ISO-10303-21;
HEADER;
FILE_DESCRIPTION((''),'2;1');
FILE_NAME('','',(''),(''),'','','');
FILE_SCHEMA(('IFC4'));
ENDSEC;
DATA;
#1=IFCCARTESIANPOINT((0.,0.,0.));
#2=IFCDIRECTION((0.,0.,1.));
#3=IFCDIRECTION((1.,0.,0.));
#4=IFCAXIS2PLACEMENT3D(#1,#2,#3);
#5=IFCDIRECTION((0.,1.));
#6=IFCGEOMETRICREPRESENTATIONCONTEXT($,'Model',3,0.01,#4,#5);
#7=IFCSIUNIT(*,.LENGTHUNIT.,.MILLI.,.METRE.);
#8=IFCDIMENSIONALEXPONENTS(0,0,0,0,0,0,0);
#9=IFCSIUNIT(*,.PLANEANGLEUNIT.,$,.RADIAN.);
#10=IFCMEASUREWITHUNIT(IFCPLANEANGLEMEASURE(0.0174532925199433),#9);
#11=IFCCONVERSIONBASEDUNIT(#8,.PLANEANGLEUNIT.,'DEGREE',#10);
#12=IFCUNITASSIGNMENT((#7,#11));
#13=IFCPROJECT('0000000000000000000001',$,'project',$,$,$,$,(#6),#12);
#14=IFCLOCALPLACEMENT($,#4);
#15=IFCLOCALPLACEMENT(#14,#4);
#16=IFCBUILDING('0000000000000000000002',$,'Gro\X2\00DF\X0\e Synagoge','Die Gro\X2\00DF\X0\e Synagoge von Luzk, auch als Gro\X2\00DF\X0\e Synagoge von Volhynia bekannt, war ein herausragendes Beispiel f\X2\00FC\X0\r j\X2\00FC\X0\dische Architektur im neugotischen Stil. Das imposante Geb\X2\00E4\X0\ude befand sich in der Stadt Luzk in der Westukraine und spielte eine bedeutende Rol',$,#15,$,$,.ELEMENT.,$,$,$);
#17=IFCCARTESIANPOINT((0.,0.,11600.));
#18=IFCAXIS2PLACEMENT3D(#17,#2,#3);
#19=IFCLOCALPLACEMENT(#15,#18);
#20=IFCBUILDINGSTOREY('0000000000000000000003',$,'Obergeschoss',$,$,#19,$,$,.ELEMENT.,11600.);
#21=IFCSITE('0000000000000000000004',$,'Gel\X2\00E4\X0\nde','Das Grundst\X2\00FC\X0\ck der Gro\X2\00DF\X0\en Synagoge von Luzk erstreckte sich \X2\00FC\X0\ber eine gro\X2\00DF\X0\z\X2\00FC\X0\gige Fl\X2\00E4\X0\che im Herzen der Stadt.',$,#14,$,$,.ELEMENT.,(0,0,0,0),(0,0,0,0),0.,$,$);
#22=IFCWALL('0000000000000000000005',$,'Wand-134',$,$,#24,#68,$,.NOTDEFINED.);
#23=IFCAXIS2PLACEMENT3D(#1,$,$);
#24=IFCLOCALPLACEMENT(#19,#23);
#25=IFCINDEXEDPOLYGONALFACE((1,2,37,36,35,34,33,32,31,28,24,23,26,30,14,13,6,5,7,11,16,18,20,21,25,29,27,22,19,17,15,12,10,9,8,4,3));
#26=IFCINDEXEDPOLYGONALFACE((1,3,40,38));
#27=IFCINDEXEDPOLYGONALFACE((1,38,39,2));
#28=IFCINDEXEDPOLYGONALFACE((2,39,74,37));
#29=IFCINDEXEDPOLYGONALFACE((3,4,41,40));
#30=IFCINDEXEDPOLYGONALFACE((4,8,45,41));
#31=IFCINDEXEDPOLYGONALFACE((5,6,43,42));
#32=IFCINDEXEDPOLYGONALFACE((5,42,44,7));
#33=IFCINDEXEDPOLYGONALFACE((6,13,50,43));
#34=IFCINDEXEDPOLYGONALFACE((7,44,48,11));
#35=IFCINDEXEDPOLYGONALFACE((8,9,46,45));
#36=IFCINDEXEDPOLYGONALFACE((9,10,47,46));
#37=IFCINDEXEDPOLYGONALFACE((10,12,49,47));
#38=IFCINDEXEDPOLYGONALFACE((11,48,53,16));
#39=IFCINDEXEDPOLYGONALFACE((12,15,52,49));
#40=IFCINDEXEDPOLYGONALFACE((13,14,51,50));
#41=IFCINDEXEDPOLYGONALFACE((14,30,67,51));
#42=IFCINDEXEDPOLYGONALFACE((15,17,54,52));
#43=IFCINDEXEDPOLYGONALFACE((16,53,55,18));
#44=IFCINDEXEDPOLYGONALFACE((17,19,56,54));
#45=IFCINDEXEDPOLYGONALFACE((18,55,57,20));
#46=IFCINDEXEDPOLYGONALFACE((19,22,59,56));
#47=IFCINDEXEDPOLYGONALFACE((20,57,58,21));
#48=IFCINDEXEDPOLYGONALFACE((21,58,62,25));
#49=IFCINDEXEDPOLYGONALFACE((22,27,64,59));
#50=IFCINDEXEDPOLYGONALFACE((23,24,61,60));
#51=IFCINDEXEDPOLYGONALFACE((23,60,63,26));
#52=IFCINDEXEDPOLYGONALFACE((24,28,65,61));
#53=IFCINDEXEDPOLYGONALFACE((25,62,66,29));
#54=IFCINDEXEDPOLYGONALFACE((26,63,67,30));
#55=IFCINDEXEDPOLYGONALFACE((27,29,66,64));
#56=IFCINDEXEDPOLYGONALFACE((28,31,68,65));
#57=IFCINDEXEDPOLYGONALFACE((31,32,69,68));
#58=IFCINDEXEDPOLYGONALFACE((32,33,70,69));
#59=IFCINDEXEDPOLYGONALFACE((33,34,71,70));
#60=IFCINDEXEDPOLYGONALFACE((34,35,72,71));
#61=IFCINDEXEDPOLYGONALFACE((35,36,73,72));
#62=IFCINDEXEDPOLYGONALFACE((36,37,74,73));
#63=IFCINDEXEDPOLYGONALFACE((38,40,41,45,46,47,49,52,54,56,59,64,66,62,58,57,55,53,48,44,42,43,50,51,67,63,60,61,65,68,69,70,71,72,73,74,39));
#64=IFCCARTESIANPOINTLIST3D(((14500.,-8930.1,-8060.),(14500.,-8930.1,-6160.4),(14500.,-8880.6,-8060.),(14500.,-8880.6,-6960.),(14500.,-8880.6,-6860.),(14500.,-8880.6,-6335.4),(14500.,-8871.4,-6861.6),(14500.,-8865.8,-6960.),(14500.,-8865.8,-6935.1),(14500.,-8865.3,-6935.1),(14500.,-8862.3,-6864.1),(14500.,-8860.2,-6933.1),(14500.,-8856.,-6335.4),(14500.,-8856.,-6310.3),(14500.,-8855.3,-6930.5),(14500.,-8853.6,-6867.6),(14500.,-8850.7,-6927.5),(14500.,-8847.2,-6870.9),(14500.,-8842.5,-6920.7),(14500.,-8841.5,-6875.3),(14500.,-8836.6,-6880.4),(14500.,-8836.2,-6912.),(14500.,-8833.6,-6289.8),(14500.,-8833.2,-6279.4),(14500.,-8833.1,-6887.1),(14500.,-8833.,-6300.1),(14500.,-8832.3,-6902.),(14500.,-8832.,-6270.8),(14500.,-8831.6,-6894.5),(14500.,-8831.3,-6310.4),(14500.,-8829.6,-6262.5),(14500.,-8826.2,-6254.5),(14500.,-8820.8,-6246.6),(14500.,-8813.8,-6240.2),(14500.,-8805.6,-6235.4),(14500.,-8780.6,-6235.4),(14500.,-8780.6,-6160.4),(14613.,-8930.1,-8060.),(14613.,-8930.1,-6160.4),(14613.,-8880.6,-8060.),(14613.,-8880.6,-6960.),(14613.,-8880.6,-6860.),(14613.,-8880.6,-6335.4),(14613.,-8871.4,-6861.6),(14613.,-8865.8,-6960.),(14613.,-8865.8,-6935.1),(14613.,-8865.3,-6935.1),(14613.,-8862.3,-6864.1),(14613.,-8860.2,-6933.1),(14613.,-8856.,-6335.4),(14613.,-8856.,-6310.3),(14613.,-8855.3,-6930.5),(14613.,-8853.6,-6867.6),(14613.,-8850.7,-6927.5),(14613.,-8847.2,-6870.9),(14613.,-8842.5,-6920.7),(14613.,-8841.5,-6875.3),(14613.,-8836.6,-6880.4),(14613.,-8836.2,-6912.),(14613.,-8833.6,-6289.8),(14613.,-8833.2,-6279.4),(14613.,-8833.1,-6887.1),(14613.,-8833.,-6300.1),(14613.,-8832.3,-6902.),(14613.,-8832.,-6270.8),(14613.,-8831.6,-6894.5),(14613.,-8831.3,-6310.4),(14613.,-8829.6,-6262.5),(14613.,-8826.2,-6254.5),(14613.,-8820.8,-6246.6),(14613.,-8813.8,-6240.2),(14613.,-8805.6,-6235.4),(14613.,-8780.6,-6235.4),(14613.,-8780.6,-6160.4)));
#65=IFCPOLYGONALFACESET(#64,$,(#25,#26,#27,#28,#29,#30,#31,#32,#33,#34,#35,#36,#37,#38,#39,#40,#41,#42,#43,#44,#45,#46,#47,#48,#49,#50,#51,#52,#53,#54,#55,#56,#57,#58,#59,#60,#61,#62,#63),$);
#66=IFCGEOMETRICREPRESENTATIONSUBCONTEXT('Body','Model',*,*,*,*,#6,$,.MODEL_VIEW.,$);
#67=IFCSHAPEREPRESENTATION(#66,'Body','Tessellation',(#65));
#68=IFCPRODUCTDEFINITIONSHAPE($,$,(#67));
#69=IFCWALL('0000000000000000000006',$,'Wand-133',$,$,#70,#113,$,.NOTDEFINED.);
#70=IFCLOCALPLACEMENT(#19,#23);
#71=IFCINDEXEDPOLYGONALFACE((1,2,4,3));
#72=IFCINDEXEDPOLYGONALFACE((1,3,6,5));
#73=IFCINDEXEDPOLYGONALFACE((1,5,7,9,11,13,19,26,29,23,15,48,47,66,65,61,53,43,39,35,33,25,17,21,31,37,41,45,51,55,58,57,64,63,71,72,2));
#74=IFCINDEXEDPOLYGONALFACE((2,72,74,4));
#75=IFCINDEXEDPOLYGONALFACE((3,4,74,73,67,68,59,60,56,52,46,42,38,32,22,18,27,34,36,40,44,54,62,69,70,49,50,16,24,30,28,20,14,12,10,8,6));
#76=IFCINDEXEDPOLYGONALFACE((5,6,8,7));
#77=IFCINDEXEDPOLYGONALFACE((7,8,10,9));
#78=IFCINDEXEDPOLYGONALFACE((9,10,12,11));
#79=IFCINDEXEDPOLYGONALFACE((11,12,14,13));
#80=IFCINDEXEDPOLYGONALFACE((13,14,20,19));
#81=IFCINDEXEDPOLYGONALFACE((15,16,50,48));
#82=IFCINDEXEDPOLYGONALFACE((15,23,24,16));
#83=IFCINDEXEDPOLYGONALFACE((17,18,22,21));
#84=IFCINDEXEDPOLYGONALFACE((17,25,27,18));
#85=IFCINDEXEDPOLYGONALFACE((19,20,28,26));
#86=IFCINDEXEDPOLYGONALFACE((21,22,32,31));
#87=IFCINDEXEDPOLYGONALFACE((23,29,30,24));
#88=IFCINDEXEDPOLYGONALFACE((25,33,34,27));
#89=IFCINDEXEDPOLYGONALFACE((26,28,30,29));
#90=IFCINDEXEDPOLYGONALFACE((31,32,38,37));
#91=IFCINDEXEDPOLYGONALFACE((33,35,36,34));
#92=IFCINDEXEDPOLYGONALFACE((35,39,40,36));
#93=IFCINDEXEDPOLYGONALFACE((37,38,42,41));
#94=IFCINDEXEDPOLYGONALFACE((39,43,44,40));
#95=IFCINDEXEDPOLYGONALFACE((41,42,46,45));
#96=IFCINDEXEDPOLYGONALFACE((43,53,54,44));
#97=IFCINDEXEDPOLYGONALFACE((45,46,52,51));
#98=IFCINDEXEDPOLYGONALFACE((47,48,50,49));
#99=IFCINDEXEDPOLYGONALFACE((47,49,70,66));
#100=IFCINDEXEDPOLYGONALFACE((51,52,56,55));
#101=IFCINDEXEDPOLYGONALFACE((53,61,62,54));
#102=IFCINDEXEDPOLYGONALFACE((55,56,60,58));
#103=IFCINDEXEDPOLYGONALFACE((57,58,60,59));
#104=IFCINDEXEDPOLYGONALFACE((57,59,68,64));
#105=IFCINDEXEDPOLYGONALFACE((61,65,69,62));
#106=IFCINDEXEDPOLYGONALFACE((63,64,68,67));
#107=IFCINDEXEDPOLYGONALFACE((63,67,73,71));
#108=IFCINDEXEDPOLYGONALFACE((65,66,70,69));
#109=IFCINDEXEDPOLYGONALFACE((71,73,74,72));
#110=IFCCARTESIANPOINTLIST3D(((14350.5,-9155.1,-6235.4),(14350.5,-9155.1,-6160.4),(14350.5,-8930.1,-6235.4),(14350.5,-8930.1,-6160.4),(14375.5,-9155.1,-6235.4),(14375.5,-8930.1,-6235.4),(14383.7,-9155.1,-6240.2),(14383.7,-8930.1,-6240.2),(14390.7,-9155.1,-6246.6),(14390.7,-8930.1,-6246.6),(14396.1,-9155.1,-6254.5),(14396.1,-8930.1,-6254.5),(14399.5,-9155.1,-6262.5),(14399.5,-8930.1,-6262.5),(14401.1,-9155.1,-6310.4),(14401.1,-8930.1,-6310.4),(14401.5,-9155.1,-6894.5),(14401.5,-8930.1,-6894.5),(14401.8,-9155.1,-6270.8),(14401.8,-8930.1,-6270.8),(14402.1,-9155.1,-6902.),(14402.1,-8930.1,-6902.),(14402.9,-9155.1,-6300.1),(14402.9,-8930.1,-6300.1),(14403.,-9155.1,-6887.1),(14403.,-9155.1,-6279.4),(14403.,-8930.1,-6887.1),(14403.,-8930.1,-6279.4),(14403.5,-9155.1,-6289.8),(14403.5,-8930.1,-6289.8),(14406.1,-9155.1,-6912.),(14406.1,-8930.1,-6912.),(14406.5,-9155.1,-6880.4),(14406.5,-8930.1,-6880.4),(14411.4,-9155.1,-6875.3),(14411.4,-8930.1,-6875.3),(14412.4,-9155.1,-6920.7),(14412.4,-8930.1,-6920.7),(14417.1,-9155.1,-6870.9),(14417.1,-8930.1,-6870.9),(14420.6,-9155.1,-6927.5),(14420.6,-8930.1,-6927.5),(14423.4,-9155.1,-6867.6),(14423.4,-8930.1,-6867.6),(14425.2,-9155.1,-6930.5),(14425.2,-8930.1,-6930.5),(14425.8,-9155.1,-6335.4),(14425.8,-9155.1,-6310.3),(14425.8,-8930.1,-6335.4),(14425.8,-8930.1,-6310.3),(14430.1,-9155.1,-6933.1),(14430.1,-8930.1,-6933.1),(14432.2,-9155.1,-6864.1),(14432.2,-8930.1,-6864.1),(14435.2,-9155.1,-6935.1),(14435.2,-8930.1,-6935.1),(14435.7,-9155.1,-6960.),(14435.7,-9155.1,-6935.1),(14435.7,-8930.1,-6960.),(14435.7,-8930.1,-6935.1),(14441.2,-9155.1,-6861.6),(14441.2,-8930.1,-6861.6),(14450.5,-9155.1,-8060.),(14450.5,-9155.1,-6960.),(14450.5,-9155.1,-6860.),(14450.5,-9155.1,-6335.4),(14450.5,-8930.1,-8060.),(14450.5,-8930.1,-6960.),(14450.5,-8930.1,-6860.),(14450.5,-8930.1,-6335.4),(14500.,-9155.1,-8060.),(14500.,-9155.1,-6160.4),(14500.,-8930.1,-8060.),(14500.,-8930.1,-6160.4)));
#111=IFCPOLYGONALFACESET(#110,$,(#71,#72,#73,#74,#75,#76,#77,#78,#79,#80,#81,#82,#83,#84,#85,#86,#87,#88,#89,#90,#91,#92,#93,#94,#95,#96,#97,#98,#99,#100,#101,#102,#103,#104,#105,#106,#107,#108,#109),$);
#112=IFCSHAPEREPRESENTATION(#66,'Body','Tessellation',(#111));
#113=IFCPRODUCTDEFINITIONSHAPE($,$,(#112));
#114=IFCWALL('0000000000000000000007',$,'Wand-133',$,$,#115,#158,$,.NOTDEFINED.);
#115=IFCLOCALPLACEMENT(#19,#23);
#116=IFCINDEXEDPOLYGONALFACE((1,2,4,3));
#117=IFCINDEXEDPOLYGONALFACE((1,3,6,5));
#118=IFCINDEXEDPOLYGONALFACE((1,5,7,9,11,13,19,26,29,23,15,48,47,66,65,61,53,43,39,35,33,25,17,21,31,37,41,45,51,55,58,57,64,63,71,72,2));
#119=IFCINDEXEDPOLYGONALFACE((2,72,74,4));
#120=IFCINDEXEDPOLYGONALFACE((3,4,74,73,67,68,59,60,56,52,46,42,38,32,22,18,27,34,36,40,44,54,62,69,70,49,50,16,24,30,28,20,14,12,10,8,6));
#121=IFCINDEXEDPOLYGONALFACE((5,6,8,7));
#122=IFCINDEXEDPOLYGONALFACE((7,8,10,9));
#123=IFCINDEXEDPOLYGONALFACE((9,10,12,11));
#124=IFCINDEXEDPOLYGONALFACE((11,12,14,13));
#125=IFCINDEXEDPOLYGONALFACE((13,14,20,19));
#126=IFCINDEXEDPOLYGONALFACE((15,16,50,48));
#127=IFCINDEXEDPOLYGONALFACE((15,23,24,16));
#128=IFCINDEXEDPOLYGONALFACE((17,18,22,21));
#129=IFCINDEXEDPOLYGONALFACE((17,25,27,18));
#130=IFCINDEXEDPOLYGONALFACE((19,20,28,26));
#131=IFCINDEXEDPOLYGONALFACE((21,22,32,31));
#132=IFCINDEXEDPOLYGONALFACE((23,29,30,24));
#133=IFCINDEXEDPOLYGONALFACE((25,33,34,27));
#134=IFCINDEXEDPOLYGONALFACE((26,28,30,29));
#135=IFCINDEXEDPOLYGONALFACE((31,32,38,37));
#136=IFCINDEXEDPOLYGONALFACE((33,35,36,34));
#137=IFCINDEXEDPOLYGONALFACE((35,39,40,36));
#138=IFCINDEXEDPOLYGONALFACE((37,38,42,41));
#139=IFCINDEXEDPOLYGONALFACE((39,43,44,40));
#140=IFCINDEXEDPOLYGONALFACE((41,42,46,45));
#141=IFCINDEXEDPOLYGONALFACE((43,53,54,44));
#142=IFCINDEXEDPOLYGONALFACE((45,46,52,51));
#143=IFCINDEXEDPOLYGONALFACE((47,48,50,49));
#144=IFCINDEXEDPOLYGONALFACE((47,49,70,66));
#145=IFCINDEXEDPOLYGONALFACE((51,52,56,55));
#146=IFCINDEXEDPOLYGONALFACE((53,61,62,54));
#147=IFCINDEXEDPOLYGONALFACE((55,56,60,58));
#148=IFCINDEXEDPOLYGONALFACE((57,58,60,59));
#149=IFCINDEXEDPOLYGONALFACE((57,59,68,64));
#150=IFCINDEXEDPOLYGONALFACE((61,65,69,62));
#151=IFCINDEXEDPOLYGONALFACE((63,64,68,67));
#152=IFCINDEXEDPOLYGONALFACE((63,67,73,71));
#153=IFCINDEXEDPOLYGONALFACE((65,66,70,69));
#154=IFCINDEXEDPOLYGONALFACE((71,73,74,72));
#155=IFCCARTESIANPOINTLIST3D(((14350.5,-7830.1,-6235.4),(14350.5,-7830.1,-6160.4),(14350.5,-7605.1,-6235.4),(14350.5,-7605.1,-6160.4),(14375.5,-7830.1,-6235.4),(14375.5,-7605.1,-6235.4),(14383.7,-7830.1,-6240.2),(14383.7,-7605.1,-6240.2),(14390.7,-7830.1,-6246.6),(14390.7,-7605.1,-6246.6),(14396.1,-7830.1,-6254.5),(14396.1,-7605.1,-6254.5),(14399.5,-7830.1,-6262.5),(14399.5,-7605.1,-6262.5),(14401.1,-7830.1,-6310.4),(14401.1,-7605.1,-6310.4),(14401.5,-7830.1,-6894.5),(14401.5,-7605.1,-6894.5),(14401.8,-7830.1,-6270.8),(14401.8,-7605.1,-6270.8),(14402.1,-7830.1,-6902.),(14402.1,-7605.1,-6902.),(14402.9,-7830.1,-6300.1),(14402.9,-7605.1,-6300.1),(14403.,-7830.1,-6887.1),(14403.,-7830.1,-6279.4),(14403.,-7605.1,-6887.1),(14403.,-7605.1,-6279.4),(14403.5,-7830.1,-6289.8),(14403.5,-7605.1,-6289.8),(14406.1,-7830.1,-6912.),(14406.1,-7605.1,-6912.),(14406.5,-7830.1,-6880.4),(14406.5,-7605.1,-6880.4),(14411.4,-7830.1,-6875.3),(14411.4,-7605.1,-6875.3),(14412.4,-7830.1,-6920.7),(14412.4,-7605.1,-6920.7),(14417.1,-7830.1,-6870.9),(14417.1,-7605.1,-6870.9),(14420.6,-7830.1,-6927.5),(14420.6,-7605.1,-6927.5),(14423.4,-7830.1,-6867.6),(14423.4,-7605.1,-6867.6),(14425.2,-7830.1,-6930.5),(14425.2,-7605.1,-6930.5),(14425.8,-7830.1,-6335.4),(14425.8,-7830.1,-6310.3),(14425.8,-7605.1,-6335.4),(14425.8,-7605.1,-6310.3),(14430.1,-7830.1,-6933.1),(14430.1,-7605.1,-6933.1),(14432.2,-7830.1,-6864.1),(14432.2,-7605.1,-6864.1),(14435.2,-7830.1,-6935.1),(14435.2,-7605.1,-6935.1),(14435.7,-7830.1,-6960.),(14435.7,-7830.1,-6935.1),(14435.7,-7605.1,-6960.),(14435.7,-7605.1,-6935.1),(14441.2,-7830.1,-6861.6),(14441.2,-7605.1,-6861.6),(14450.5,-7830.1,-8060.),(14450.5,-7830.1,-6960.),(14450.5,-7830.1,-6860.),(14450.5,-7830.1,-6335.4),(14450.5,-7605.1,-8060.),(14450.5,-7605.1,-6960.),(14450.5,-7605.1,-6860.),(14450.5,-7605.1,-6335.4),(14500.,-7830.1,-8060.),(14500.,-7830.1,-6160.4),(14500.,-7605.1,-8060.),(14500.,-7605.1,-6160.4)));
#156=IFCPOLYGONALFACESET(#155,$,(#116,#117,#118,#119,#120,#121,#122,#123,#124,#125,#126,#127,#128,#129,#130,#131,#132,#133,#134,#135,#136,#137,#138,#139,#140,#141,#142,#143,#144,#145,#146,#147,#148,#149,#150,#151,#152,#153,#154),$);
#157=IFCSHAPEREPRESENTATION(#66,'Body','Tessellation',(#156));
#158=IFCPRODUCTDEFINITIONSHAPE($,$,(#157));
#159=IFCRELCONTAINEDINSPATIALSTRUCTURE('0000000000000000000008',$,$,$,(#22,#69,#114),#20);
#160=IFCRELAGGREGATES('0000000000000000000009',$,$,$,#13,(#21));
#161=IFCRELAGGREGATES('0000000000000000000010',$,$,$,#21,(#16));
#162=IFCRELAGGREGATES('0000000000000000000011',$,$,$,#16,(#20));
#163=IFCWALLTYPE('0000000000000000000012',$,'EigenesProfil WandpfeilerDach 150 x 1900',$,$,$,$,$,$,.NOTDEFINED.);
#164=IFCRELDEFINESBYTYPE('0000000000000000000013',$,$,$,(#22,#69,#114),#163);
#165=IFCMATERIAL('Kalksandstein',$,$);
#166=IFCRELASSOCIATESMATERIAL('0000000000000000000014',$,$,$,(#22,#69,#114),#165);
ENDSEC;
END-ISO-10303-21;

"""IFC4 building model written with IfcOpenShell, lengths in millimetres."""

from ifc_helpers import new_model, entity, si_unit, converted_unit, direction, frame, origin_with_axes, place, context, subcontext, project, spatial, line, arc, indexed_curve, outline, extrude, material, material_profile, profile_set, type_object, element, save


model = new_model("IFC4")

# Units and contexts
model_context = context("Model", 3, precision=0.01, world=origin_with_axes(), true_north=direction((0.0, 1.0)))
body_context = subcontext(model_context, "Body", "Model", "MODEL_VIEW")
ifc_project = project(units=[si_unit("LENGTHUNIT", "METRE", prefix="MILLI"), converted_unit("PLANEANGLEUNIT", "DEGREE", entity("IfcPlaneAngleMeasure", 0.0174532925199433), si_unit("PLANEANGLEUNIT", "RADIAN"), dimensions=[0, 0, 0, 0, 0, 0, 0])], contexts=[model_context])

# Site, building, storey
site_placement = place(None, origin_with_axes())
site = spatial("IfcSite", under=ifc_project, at=site_placement, Name="Gelände", Description="Das Grundstück der Großen Synagoge von Luzk erstreckte sich über eine großzügige Fläche im Herzen der Stadt.", CompositionType="ELEMENT", RefLatitude=(0, 0, 0, 0), RefLongitude=(0, 0, 0, 0), RefElevation=0.0)
building_placement = place(site_placement, origin_with_axes())
building = spatial("IfcBuilding", under=site, at=building_placement, Name="Große Synagoge", Description="Die Große Synagoge von Luzk, auch als Große Synagoge von Volhynia bekannt, war ein herausragendes Beispiel für jüdische Architektur im neugotischen Stil. Das imposante Gebäude befand sich in der Stadt Luzk in der Westukraine und spielte eine bedeutende Rol", CompositionType="ELEMENT")
storey_placement = place(building_placement, frame((0.0, 0.0, 11600.0), z_axis=(0.0, 0.0, 1.0), x_axis=(1.0, 0.0, 0.0)))
storey = spatial("IfcBuildingStorey", under=building, at=storey_placement, Name="Obergeschoss", CompositionType="ELEMENT", Elevation=11600.0)

# Walls
ifc_material_1 = material(Name="Kalksandstein")
ifc_material_profile = material_profile(ifc_material_1, outline(indexed_curve([(74.2, 1749.6), (98.9, 1749.6), (96.7, 1765.0), (97.0, 1780.5), (99.2, 1793.4), (103.9, 1805.5), (112.6, 1816.7), (124.5, 1824.6), (149.5, 1824.6), (149.5, 1899.6), (0.0, 1899.6), (0.0, 0.0), (49.5, 0.0), (49.5, 1100.0), (64.3, 1100.0), (64.3, 1124.9), (64.8, 1124.9), (72.4, 1128.1), (79.4, 1132.4), (91.1, 1143.4), (97.9, 1157.9), (98.0, 1169.2), (93.5, 1179.5), (85.8, 1187.0), (76.6, 1192.3), (63.3, 1197.2), (49.5, 1200.0), (49.5, 1724.6), (74.2, 1724.6)], segments=[line(1, 2), arc(2, 3, 4), arc(4, 5, 6), arc(6, 7, 8), line(8, 9, 10, 11, 12, 13, 14, 15, 16, 17), arc(17, 18, 19), arc(19, 20, 21), arc(21, 22, 23), arc(23, 24, 25), arc(25, 26, 27), line(27, 28, 29, 1)])), Name="Kalksandstein")
ifc_profile_set = profile_set([ifc_material_profile], Name="EigenesProfil WandpfeilerDach")
wall_type_1 = type_object("IfcWallType", Name="EigenesProfil WandpfeilerDach 150 x 1900", PredefinedType="NOTDEFINED")
wall_1_placement = place(storey_placement, frame((14500.0, -8930.1, -8060.0), z_axis=(0.0, 0.0, 1.0), x_axis=(1.0, 0.0, 0.0)))
element("IfcWall", 1, at=wall_1_placement, inside=storey, type_object=wall_type_1, material=ifc_profile_set, Name="Wand-134", PredefinedType="NOTDEFINED", context=body_context, shape_type="SweptSolid", body=[
    extrude(outline(indexed_curve([(74.2, 1749.6), (98.9, 1749.6), (96.7, 1765.0), (97.0, 1780.5), (99.2, 1793.4), (103.9, 1805.5), (112.6, 1816.7), (124.5, 1824.6), (149.5, 1824.6), (149.5, 1899.6), (0.0, 1899.6), (0.0, 0.0), (49.5, 0.0), (49.5, 1100.0), (64.3, 1100.0), (64.3, 1124.9), (64.8, 1124.9), (72.4, 1128.1), (79.4, 1132.4), (91.1, 1143.4), (97.9, 1157.9), (98.0, 1169.2), (93.5, 1179.5), (85.8, 1187.0), (76.6, 1192.3), (63.3, 1197.2), (49.5, 1200.0), (49.5, 1724.6), (74.2, 1724.6)], segments=[line(1, 2), arc(2, 3, 4), arc(4, 5, 6), arc(6, 7, 8), line(8, 9, 10, 11, 12, 13, 14, 15, 16, 17), arc(17, 18, 19), arc(19, 20, 21), arc(21, 22, 23), arc(23, 24, 25), arc(25, 26, 27), line(27, 28, 29, 1)])), frame((0.0, 0.0, 0.0), z_axis=(1.0, 0.0, 0.0), x_axis=(0.0, 1.0, 0.0)), (0.0, 0.0, 1.0), 113.0),
])
for number, where, z_axis, x_axis, name in (
    (2, (14500.0, -8930.1, -8060.0), (0.0, 0.0, 1.0), (0.0, -1.0, 0.0), "Wand-133"),
    (3, (14500.0, -7605.1, -8060.0), (0.0, 0.0, 1.0), (0.0, -1.0, 0.0), "Wand-133"),
):
    element("IfcWall", number, at=place(storey_placement, frame(where, z_axis=z_axis, x_axis=x_axis)), inside=storey, type_object=wall_type_1, material=ifc_profile_set, Name=name, PredefinedType="NOTDEFINED", context=body_context, shape_type="SweptSolid", body=[
        extrude(outline(indexed_curve([(74.2, 1749.6), (98.9, 1749.6), (96.7, 1765.0), (97.0, 1780.5), (99.2, 1793.4), (103.9, 1805.5), (112.6, 1816.7), (124.5, 1824.6), (149.5, 1824.6), (149.5, 1899.6), (0.0, 1899.6), (0.0, 0.0), (49.5, 0.0), (49.5, 1100.0), (64.3, 1100.0), (64.3, 1124.9), (64.8, 1124.9), (72.4, 1128.1), (79.4, 1132.4), (91.1, 1143.4), (97.9, 1157.9), (98.0, 1169.2), (93.5, 1179.5), (85.8, 1187.0), (76.6, 1192.3), (63.3, 1197.2), (49.5, 1200.0), (49.5, 1724.6), (74.2, 1724.6)], segments=[line(1, 2), arc(2, 3, 4), arc(4, 5, 6), arc(6, 7, 8), line(8, 9, 10, 11, 12, 13, 14, 15, 16, 17), arc(17, 18, 19), arc(19, 20, 21), arc(21, 22, 23), arc(23, 24, 25), arc(25, 26, 27), line(27, 28, 29, 1)])), frame((0.0, 0.0, 0.0), z_axis=(-1.0, 0.0, 0.0), x_axis=(0.0, -1.0, 0.0)), (0.0, 0.0, -1.0), 225.0),
    ])

save(model, "model.ifc")
